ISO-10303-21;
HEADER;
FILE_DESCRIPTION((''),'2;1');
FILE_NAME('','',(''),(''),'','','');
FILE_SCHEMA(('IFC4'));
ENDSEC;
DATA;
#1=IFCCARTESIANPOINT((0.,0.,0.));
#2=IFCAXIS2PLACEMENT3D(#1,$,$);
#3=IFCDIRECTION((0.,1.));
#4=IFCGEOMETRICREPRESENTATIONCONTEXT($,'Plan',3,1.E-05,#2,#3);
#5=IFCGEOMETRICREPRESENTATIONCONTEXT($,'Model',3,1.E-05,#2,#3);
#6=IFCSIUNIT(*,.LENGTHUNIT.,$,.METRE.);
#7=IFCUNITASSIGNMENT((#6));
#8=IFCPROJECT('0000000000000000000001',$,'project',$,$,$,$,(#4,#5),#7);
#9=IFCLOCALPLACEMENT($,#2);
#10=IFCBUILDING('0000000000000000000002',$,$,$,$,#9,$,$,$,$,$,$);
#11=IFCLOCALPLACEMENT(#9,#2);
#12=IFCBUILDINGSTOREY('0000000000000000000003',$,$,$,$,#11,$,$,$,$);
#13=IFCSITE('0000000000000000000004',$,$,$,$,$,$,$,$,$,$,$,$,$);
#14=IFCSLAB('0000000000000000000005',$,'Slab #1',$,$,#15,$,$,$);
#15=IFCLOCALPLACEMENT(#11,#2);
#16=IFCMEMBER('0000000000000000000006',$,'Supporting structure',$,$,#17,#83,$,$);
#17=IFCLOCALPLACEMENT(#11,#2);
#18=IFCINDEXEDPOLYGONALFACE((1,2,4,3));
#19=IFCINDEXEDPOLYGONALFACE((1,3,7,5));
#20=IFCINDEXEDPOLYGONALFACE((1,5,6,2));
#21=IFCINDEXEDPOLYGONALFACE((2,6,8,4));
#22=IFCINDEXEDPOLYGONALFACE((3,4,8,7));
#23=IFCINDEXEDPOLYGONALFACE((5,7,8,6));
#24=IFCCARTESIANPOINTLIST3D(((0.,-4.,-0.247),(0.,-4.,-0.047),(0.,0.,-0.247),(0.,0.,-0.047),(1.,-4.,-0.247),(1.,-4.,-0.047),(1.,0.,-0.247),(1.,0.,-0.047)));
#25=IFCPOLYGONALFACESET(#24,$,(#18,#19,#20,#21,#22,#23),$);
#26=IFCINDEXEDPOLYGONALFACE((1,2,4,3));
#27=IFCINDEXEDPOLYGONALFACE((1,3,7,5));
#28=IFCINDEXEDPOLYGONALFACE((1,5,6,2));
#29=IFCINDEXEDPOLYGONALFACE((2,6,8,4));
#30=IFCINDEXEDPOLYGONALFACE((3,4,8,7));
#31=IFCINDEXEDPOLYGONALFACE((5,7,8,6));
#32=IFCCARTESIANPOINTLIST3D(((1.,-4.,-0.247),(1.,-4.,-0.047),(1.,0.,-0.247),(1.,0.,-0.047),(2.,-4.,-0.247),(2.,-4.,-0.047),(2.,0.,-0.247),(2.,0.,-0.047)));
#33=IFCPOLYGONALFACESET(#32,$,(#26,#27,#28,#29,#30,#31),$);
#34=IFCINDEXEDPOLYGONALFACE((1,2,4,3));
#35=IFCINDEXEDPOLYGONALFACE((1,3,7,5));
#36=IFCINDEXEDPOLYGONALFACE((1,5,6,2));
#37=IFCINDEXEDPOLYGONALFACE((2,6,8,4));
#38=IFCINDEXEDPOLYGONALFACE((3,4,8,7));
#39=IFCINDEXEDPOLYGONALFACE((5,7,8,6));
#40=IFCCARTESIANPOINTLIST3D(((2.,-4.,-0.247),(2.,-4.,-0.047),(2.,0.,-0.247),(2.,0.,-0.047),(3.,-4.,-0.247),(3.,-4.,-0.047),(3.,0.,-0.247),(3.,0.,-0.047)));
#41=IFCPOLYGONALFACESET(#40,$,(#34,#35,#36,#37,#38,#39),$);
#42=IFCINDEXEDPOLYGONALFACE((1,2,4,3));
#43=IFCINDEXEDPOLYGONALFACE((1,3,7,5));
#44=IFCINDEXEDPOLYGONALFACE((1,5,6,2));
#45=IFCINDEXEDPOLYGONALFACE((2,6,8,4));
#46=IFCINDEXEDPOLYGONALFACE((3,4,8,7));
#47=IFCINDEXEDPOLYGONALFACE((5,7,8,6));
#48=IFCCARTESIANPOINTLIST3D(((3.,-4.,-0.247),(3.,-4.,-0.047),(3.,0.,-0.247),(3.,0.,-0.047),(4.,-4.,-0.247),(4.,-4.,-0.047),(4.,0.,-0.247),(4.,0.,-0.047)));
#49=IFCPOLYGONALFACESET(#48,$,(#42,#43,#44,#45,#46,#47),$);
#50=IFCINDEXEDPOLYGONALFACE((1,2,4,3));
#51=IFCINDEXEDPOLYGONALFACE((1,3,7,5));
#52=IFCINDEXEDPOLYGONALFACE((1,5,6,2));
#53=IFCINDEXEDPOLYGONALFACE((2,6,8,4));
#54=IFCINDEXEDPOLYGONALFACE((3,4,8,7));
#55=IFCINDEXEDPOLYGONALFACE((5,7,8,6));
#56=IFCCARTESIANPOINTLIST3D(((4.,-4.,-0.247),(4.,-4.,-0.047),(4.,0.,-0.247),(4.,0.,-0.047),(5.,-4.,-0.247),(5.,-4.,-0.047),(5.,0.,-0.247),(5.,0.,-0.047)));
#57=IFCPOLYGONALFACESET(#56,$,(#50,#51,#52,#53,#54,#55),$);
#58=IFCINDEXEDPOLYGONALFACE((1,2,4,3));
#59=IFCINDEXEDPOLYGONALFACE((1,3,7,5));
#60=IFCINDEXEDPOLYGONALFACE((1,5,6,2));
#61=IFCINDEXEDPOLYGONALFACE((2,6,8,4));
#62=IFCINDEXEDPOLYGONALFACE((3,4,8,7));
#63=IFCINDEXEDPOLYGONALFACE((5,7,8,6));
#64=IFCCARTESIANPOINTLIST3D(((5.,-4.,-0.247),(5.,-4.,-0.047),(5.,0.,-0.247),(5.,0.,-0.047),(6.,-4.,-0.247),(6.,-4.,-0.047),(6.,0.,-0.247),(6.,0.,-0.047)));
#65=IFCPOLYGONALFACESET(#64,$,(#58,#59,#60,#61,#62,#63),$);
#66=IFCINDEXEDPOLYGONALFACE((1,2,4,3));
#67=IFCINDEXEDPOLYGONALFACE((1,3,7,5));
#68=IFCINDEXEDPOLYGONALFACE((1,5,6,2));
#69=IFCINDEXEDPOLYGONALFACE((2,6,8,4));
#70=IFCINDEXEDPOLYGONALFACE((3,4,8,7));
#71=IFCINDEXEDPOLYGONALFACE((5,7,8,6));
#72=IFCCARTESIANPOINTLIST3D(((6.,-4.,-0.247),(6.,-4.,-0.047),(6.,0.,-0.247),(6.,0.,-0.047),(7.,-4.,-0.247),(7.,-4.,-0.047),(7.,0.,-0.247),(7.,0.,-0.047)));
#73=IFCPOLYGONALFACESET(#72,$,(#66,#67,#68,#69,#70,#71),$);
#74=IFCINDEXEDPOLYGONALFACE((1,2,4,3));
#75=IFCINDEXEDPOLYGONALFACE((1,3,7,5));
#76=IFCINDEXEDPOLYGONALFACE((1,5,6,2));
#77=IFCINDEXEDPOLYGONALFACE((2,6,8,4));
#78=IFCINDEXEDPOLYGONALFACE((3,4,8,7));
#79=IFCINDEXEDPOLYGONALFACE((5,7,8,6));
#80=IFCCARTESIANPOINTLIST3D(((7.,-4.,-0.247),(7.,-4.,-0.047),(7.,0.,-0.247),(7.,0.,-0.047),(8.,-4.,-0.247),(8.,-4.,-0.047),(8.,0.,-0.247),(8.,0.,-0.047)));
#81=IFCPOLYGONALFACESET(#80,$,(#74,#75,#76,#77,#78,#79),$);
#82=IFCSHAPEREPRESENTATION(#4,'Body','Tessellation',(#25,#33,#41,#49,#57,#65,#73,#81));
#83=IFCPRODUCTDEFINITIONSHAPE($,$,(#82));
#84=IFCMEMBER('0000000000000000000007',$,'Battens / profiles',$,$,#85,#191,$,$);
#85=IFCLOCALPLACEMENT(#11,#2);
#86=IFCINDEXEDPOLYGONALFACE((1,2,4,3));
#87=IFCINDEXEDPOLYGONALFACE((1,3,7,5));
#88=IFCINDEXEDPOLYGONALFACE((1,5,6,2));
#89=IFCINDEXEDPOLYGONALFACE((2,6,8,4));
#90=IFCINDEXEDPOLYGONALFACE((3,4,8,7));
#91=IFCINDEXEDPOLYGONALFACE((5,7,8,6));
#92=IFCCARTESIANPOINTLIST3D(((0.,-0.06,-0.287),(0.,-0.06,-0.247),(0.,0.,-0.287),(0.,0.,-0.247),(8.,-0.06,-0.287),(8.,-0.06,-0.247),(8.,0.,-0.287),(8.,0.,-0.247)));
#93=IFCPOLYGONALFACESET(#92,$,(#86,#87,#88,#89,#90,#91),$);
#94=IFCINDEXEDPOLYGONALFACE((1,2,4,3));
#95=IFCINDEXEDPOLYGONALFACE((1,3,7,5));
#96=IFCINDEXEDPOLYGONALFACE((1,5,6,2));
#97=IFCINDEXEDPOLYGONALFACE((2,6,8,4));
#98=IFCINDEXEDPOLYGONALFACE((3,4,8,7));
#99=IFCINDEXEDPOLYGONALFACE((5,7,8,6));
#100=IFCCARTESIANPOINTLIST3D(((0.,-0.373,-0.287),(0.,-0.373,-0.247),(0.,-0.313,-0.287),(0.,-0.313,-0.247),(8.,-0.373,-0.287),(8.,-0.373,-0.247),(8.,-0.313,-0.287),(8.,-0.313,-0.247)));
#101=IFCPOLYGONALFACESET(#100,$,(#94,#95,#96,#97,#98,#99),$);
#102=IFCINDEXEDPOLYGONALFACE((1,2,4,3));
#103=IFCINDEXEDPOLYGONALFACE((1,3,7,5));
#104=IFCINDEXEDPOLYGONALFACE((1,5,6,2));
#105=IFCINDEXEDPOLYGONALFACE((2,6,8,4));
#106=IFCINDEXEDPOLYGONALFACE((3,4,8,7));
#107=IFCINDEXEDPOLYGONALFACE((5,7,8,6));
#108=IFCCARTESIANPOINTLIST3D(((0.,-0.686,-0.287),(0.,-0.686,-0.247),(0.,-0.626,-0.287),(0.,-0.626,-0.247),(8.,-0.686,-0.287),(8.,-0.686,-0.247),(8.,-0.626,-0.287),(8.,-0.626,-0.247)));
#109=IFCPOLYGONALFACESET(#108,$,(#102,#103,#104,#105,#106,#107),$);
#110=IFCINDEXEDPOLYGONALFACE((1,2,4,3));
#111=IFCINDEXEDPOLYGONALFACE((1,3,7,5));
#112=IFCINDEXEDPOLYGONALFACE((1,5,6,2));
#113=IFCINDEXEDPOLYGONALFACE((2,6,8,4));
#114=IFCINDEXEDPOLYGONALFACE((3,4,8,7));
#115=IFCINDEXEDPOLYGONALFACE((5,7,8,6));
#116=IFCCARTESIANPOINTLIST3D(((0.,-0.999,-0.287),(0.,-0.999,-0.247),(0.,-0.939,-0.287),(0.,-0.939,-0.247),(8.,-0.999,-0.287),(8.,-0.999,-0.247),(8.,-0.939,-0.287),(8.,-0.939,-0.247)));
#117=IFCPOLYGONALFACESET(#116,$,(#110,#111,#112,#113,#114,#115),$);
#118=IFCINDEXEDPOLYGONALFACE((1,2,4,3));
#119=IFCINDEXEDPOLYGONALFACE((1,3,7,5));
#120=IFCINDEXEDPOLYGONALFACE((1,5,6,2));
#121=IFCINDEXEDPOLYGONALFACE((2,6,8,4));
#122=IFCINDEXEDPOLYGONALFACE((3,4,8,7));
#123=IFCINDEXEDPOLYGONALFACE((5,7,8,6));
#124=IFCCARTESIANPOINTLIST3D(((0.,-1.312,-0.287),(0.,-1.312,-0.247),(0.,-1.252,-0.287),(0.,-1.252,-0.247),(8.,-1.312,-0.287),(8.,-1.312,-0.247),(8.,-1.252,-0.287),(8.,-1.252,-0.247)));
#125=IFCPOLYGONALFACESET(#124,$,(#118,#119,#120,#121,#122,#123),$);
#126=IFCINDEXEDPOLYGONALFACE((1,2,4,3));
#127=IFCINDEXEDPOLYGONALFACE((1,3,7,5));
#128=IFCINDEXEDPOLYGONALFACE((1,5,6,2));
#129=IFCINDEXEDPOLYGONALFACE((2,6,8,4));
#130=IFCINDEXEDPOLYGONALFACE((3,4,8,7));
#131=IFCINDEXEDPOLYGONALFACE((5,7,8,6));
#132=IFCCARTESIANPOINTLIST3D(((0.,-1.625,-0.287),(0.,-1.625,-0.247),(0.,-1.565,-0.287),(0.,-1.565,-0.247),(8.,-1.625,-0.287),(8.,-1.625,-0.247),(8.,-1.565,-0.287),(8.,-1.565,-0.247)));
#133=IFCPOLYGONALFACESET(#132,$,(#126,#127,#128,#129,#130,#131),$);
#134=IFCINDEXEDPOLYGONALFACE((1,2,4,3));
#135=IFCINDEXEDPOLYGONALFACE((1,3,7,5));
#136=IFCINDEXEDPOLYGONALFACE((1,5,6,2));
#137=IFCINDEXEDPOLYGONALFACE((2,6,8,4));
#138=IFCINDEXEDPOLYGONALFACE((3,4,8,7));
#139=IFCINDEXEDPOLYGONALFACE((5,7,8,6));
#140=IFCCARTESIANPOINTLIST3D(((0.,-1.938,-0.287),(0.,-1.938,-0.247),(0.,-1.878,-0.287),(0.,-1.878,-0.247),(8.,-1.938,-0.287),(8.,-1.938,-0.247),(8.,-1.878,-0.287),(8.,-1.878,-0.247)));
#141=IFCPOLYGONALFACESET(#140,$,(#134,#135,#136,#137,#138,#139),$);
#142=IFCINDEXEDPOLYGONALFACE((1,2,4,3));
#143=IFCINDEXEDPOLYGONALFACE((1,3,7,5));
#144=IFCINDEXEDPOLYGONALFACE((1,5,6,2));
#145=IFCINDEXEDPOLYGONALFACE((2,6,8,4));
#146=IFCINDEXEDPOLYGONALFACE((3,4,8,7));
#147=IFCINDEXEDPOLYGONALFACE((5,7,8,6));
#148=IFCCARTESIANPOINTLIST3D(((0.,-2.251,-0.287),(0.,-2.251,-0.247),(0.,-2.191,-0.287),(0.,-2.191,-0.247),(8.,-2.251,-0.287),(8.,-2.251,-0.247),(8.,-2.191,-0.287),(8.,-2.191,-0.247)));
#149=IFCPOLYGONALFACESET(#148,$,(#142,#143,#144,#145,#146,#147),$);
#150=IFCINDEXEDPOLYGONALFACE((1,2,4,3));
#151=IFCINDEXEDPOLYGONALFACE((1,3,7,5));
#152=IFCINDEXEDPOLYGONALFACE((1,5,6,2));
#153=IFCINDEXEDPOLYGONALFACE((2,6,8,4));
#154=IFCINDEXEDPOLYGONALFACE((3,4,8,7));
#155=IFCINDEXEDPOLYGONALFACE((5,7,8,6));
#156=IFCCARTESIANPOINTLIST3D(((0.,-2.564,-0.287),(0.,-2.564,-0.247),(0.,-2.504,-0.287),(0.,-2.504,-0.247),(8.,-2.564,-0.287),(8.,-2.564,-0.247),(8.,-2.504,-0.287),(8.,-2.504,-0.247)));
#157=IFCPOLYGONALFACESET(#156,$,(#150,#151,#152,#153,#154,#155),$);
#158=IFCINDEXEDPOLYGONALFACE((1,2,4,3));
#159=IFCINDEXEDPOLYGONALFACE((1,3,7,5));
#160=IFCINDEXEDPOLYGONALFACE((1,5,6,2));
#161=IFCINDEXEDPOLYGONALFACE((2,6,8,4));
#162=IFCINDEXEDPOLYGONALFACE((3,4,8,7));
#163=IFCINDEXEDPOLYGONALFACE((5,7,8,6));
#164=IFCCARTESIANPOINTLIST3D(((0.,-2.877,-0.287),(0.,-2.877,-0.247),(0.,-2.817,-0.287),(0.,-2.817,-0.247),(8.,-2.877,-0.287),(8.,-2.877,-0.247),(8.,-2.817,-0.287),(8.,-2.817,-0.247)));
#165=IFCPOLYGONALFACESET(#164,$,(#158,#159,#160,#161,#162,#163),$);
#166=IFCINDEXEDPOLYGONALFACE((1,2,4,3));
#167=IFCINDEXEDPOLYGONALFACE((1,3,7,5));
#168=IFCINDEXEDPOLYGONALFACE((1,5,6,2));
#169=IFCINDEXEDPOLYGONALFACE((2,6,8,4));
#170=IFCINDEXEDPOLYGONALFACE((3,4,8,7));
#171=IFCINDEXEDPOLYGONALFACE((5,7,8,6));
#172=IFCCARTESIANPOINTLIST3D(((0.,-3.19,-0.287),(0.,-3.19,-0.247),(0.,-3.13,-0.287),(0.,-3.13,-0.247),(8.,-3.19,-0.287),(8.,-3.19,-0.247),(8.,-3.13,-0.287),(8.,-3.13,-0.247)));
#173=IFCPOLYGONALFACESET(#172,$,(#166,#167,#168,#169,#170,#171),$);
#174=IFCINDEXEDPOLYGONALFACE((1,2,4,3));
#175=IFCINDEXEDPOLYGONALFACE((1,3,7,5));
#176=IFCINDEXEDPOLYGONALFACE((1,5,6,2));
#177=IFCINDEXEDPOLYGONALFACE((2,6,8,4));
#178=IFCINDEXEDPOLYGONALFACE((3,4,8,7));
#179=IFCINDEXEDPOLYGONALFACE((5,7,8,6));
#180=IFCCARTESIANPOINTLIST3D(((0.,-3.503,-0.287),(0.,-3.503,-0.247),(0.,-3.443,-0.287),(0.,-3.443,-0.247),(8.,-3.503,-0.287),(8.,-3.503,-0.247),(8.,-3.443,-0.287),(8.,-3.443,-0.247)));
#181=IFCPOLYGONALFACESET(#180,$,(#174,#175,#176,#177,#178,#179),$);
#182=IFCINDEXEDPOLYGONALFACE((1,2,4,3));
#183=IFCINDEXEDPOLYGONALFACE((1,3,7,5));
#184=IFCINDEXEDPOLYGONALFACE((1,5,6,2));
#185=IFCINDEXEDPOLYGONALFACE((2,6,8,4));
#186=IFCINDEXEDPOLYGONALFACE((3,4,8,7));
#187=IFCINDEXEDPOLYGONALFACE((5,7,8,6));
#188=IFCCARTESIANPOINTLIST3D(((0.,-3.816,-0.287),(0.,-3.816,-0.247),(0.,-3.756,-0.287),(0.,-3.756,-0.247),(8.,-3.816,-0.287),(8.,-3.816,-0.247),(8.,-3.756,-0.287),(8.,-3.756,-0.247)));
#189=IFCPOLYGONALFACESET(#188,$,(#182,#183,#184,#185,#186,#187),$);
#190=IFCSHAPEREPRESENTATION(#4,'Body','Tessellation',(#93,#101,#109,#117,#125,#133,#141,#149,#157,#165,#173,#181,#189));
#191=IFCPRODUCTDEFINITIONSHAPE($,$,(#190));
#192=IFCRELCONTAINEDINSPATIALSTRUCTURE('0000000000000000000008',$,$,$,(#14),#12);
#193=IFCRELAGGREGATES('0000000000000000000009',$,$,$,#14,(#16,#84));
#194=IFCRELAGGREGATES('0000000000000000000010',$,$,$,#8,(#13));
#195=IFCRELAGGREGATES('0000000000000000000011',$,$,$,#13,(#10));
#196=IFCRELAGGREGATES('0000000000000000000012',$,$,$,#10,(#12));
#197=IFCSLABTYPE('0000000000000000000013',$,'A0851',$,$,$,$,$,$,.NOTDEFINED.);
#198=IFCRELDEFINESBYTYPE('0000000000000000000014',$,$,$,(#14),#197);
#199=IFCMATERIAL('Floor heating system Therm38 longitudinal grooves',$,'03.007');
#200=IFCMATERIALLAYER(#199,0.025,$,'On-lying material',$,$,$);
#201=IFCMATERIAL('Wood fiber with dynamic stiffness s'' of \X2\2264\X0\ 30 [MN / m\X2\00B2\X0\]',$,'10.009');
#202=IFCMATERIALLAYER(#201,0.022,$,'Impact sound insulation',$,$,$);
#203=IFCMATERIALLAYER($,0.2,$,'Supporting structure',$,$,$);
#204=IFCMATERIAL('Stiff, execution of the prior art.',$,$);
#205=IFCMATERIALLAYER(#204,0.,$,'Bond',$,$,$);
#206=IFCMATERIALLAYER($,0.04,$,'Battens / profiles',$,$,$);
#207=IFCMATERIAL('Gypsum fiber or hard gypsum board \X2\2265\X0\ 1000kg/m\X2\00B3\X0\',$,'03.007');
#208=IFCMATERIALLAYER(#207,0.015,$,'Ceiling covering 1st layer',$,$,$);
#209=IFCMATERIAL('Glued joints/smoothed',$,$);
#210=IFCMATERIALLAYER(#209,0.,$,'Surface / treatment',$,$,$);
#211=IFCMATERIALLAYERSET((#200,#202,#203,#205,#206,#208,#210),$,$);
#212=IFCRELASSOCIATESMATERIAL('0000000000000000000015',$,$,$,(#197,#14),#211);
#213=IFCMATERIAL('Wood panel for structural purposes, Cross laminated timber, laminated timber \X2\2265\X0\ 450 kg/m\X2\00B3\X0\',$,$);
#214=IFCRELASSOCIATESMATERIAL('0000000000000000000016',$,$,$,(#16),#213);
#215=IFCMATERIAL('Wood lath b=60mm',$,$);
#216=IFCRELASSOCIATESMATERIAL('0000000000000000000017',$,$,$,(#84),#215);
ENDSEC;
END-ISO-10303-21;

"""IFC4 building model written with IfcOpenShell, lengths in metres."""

from ifc_helpers import new_model, si_unit, direction, frame, frame_2d, origin, place, context, project, spatial, rectangle, extrude, material, layer, layer_set, type_object, element, aggregate, save


model = new_model("IFC4")

# Units and contexts
plan_context = context("Plan", 3, precision=1e-05, world=origin(), true_north=direction((0.0, 1.0)))
model_context = context("Model", 3, precision=1e-05, world=origin(), true_north=direction((0.0, 1.0)))
ifc_project = project(units=[si_unit("LENGTHUNIT", "METRE")], contexts=[plan_context, model_context])

# Site, building, storey
site = spatial("IfcSite", under=ifc_project)
building_placement = place(None, origin())
building = spatial("IfcBuilding", under=site, at=building_placement)
storey_placement = place(building_placement, origin())
storey = spatial("IfcBuildingStorey", under=building, at=storey_placement)

# Slab, members
ifc_material_1 = material(Name="Floor heating system Therm38 longitudinal grooves", Category="03.007")
ifc_layer_1 = layer(ifc_material_1, 0.025, Name="On-lying material")
ifc_material_2 = material(Name="Wood fiber with dynamic stiffness s' of ≤ 30 [MN / m²]", Category="10.009")
ifc_layer_2 = layer(ifc_material_2, 0.022, Name="Impact sound insulation")
ifc_layer_3 = layer(None, 0.2, Name="Supporting structure")
ifc_material_3 = material(Name="Stiff, execution of the prior art.")
ifc_layer_4 = layer(ifc_material_3, 0.0, Name="Bond")
ifc_layer_5 = layer(None, 0.04, Name="Battens / profiles")
ifc_material_4 = material(Name="Gypsum fiber or hard gypsum board ≥ 1000kg/m³", Category="03.007")
ifc_layer_6 = layer(ifc_material_4, 0.015, Name="Ceiling covering 1st layer")
ifc_material_5 = material(Name="Glued joints/smoothed")
ifc_layer_7 = layer(ifc_material_5, 0.0, Name="Surface / treatment")
ifc_layer_set = layer_set([ifc_layer_1, ifc_layer_2, ifc_layer_3, ifc_layer_4, ifc_layer_5, ifc_layer_6, ifc_layer_7])
slab_type = type_object("IfcSlabType", Name="A0851", PredefinedType="NOTDEFINED", material=ifc_layer_set)
slab_placement = place(None, frame((0.0, 0.0, 0.0), z_axis=(0.0, 0.0, -1.0), x_axis=(1.0, 0.0, 0.0)))
slab = element("IfcSlab", 1, at=slab_placement, inside=storey, type_object=slab_type, material=ifc_layer_set, Name="Slab #1")
ifc_material_6 = material(Name="Wood panel for structural purposes, Cross laminated timber, laminated timber ≥ 450 kg/m³")
member_1_placement = place(slab_placement, origin())
member_1 = element("IfcMember", 2, at=member_1_placement, material=ifc_material_6, Name="Supporting structure", context=plan_context, shape_type="SweptSolid", body=[
    extrude(rectangle(XDim=1.0, YDim=0.2, at=frame_2d((0.5, 0.1), x_axis=(1.0, 0.0))), frame((0.0, 4.0, 0.047), z_axis=(0.0, -1.0, 0.0), x_axis=(1.0, 0.0, 0.0)), (0.0, 0.0, 1.0), 4.0),
    extrude(rectangle(XDim=1.0, YDim=0.2, at=frame_2d((0.5, 0.1), x_axis=(1.0, 0.0))), frame((1.0, 4.0, 0.047), z_axis=(0.0, -1.0, 0.0), x_axis=(1.0, 0.0, 0.0)), (0.0, 0.0, 1.0), 4.0),
    extrude(rectangle(XDim=1.0, YDim=0.2, at=frame_2d((0.5, 0.1), x_axis=(1.0, 0.0))), frame((2.0, 4.0, 0.047), z_axis=(0.0, -1.0, 0.0), x_axis=(1.0, 0.0, 0.0)), (0.0, 0.0, 1.0), 4.0),
    extrude(rectangle(XDim=1.0, YDim=0.2, at=frame_2d((0.5, 0.1), x_axis=(1.0, 0.0))), frame((3.0, 4.0, 0.047), z_axis=(0.0, -1.0, 0.0), x_axis=(1.0, 0.0, 0.0)), (0.0, 0.0, 1.0), 4.0),
    extrude(rectangle(XDim=1.0, YDim=0.2, at=frame_2d((0.5, 0.1), x_axis=(1.0, 0.0))), frame((4.0, 4.0, 0.047), z_axis=(0.0, -1.0, 0.0), x_axis=(1.0, 0.0, 0.0)), (0.0, 0.0, 1.0), 4.0),
    extrude(rectangle(XDim=1.0, YDim=0.2, at=frame_2d((0.5, 0.1), x_axis=(1.0, 0.0))), frame((5.0, 4.0, 0.047), z_axis=(0.0, -1.0, 0.0), x_axis=(1.0, 0.0, 0.0)), (0.0, 0.0, 1.0), 4.0),
    extrude(rectangle(XDim=1.0, YDim=0.2, at=frame_2d((0.5, 0.1), x_axis=(1.0, 0.0))), frame((6.0, 4.0, 0.047), z_axis=(0.0, -1.0, 0.0), x_axis=(1.0, 0.0, 0.0)), (0.0, 0.0, 1.0), 4.0),
    extrude(rectangle(XDim=1.0, YDim=0.2, at=frame_2d((0.5, 0.1), x_axis=(1.0, 0.0))), frame((7.0, 4.0, 0.047), z_axis=(0.0, -1.0, 0.0), x_axis=(1.0, 0.0, 0.0)), (0.0, 0.0, 1.0), 4.0),
])
ifc_material_7 = material(Name="Wood lath b=60mm")
member_2_placement = place(slab_placement, origin())
member_2 = element("IfcMember", 3, at=member_2_placement, material=ifc_material_7, Name="Battens / profiles", context=plan_context, shape_type="SweptSolid", body=[
    extrude(rectangle(XDim=0.06, YDim=0.04, at=frame_2d((0.03, 0.02), x_axis=(1.0, 0.0))), frame((0.0, 0.0, 0.247), z_axis=(1.0, 0.0, 0.0), x_axis=(0.0, 1.0, 0.0)), (0.0, 0.0, 1.0), 8.0),
    extrude(rectangle(XDim=0.06, YDim=0.04, at=frame_2d((0.03, 0.02), x_axis=(1.0, 0.0))), frame((0.0, 0.313, 0.247), z_axis=(1.0, 0.0, 0.0), x_axis=(0.0, 1.0, 0.0)), (0.0, 0.0, 1.0), 8.0),
    extrude(rectangle(XDim=0.06, YDim=0.04, at=frame_2d((0.03, 0.02), x_axis=(1.0, 0.0))), frame((0.0, 0.626, 0.247), z_axis=(1.0, 0.0, 0.0), x_axis=(0.0, 1.0, 0.0)), (0.0, 0.0, 1.0), 8.0),
    extrude(rectangle(XDim=0.06, YDim=0.04, at=frame_2d((0.03, 0.02), x_axis=(1.0, 0.0))), frame((0.0, 0.939, 0.247), z_axis=(1.0, 0.0, 0.0), x_axis=(0.0, 1.0, 0.0)), (0.0, 0.0, 1.0), 8.0),
    extrude(rectangle(XDim=0.06, YDim=0.04, at=frame_2d((0.03, 0.02), x_axis=(1.0, 0.0))), frame((0.0, 1.252, 0.247), z_axis=(1.0, 0.0, 0.0), x_axis=(0.0, 1.0, 0.0)), (0.0, 0.0, 1.0), 8.0),
    extrude(rectangle(XDim=0.06, YDim=0.04, at=frame_2d((0.03, 0.02), x_axis=(1.0, 0.0))), frame((0.0, 1.565, 0.247), z_axis=(1.0, 0.0, 0.0), x_axis=(0.0, 1.0, 0.0)), (0.0, 0.0, 1.0), 8.0),
    extrude(rectangle(XDim=0.06, YDim=0.04, at=frame_2d((0.03, 0.02), x_axis=(1.0, 0.0))), frame((0.0, 1.878, 0.247), z_axis=(1.0, 0.0, 0.0), x_axis=(0.0, 1.0, 0.0)), (0.0, 0.0, 1.0), 8.0),
    extrude(rectangle(XDim=0.06, YDim=0.04, at=frame_2d((0.03, 0.02), x_axis=(1.0, 0.0))), frame((0.0, 2.191, 0.247), z_axis=(1.0, 0.0, 0.0), x_axis=(0.0, 1.0, 0.0)), (0.0, 0.0, 1.0), 8.0),
    extrude(rectangle(XDim=0.06, YDim=0.04, at=frame_2d((0.03, 0.02), x_axis=(1.0, 0.0))), frame((0.0, 2.504, 0.247), z_axis=(1.0, 0.0, 0.0), x_axis=(0.0, 1.0, 0.0)), (0.0, 0.0, 1.0), 8.0),
    extrude(rectangle(XDim=0.06, YDim=0.04, at=frame_2d((0.03, 0.02), x_axis=(1.0, 0.0))), frame((0.0, 2.817, 0.247), z_axis=(1.0, 0.0, 0.0), x_axis=(0.0, 1.0, 0.0)), (0.0, 0.0, 1.0), 8.0),
    extrude(rectangle(XDim=0.06, YDim=0.04, at=frame_2d((0.03, 0.02), x_axis=(1.0, 0.0))), frame((0.0, 3.13, 0.247), z_axis=(1.0, 0.0, 0.0), x_axis=(0.0, 1.0, 0.0)), (0.0, 0.0, 1.0), 8.0),
    extrude(rectangle(XDim=0.06, YDim=0.04, at=frame_2d((0.03, 0.02), x_axis=(1.0, 0.0))), frame((0.0, 3.443, 0.247), z_axis=(1.0, 0.0, 0.0), x_axis=(0.0, 1.0, 0.0)), (0.0, 0.0, 1.0), 8.0),
    extrude(rectangle(XDim=0.06, YDim=0.04, at=frame_2d((0.03, 0.02), x_axis=(1.0, 0.0))), frame((0.0, 3.756, 0.247), z_axis=(1.0, 0.0, 0.0), x_axis=(0.0, 1.0, 0.0)), (0.0, 0.0, 1.0), 8.0),
])
aggregate(slab, [member_1, member_2])

save(model, "model.ifc")
